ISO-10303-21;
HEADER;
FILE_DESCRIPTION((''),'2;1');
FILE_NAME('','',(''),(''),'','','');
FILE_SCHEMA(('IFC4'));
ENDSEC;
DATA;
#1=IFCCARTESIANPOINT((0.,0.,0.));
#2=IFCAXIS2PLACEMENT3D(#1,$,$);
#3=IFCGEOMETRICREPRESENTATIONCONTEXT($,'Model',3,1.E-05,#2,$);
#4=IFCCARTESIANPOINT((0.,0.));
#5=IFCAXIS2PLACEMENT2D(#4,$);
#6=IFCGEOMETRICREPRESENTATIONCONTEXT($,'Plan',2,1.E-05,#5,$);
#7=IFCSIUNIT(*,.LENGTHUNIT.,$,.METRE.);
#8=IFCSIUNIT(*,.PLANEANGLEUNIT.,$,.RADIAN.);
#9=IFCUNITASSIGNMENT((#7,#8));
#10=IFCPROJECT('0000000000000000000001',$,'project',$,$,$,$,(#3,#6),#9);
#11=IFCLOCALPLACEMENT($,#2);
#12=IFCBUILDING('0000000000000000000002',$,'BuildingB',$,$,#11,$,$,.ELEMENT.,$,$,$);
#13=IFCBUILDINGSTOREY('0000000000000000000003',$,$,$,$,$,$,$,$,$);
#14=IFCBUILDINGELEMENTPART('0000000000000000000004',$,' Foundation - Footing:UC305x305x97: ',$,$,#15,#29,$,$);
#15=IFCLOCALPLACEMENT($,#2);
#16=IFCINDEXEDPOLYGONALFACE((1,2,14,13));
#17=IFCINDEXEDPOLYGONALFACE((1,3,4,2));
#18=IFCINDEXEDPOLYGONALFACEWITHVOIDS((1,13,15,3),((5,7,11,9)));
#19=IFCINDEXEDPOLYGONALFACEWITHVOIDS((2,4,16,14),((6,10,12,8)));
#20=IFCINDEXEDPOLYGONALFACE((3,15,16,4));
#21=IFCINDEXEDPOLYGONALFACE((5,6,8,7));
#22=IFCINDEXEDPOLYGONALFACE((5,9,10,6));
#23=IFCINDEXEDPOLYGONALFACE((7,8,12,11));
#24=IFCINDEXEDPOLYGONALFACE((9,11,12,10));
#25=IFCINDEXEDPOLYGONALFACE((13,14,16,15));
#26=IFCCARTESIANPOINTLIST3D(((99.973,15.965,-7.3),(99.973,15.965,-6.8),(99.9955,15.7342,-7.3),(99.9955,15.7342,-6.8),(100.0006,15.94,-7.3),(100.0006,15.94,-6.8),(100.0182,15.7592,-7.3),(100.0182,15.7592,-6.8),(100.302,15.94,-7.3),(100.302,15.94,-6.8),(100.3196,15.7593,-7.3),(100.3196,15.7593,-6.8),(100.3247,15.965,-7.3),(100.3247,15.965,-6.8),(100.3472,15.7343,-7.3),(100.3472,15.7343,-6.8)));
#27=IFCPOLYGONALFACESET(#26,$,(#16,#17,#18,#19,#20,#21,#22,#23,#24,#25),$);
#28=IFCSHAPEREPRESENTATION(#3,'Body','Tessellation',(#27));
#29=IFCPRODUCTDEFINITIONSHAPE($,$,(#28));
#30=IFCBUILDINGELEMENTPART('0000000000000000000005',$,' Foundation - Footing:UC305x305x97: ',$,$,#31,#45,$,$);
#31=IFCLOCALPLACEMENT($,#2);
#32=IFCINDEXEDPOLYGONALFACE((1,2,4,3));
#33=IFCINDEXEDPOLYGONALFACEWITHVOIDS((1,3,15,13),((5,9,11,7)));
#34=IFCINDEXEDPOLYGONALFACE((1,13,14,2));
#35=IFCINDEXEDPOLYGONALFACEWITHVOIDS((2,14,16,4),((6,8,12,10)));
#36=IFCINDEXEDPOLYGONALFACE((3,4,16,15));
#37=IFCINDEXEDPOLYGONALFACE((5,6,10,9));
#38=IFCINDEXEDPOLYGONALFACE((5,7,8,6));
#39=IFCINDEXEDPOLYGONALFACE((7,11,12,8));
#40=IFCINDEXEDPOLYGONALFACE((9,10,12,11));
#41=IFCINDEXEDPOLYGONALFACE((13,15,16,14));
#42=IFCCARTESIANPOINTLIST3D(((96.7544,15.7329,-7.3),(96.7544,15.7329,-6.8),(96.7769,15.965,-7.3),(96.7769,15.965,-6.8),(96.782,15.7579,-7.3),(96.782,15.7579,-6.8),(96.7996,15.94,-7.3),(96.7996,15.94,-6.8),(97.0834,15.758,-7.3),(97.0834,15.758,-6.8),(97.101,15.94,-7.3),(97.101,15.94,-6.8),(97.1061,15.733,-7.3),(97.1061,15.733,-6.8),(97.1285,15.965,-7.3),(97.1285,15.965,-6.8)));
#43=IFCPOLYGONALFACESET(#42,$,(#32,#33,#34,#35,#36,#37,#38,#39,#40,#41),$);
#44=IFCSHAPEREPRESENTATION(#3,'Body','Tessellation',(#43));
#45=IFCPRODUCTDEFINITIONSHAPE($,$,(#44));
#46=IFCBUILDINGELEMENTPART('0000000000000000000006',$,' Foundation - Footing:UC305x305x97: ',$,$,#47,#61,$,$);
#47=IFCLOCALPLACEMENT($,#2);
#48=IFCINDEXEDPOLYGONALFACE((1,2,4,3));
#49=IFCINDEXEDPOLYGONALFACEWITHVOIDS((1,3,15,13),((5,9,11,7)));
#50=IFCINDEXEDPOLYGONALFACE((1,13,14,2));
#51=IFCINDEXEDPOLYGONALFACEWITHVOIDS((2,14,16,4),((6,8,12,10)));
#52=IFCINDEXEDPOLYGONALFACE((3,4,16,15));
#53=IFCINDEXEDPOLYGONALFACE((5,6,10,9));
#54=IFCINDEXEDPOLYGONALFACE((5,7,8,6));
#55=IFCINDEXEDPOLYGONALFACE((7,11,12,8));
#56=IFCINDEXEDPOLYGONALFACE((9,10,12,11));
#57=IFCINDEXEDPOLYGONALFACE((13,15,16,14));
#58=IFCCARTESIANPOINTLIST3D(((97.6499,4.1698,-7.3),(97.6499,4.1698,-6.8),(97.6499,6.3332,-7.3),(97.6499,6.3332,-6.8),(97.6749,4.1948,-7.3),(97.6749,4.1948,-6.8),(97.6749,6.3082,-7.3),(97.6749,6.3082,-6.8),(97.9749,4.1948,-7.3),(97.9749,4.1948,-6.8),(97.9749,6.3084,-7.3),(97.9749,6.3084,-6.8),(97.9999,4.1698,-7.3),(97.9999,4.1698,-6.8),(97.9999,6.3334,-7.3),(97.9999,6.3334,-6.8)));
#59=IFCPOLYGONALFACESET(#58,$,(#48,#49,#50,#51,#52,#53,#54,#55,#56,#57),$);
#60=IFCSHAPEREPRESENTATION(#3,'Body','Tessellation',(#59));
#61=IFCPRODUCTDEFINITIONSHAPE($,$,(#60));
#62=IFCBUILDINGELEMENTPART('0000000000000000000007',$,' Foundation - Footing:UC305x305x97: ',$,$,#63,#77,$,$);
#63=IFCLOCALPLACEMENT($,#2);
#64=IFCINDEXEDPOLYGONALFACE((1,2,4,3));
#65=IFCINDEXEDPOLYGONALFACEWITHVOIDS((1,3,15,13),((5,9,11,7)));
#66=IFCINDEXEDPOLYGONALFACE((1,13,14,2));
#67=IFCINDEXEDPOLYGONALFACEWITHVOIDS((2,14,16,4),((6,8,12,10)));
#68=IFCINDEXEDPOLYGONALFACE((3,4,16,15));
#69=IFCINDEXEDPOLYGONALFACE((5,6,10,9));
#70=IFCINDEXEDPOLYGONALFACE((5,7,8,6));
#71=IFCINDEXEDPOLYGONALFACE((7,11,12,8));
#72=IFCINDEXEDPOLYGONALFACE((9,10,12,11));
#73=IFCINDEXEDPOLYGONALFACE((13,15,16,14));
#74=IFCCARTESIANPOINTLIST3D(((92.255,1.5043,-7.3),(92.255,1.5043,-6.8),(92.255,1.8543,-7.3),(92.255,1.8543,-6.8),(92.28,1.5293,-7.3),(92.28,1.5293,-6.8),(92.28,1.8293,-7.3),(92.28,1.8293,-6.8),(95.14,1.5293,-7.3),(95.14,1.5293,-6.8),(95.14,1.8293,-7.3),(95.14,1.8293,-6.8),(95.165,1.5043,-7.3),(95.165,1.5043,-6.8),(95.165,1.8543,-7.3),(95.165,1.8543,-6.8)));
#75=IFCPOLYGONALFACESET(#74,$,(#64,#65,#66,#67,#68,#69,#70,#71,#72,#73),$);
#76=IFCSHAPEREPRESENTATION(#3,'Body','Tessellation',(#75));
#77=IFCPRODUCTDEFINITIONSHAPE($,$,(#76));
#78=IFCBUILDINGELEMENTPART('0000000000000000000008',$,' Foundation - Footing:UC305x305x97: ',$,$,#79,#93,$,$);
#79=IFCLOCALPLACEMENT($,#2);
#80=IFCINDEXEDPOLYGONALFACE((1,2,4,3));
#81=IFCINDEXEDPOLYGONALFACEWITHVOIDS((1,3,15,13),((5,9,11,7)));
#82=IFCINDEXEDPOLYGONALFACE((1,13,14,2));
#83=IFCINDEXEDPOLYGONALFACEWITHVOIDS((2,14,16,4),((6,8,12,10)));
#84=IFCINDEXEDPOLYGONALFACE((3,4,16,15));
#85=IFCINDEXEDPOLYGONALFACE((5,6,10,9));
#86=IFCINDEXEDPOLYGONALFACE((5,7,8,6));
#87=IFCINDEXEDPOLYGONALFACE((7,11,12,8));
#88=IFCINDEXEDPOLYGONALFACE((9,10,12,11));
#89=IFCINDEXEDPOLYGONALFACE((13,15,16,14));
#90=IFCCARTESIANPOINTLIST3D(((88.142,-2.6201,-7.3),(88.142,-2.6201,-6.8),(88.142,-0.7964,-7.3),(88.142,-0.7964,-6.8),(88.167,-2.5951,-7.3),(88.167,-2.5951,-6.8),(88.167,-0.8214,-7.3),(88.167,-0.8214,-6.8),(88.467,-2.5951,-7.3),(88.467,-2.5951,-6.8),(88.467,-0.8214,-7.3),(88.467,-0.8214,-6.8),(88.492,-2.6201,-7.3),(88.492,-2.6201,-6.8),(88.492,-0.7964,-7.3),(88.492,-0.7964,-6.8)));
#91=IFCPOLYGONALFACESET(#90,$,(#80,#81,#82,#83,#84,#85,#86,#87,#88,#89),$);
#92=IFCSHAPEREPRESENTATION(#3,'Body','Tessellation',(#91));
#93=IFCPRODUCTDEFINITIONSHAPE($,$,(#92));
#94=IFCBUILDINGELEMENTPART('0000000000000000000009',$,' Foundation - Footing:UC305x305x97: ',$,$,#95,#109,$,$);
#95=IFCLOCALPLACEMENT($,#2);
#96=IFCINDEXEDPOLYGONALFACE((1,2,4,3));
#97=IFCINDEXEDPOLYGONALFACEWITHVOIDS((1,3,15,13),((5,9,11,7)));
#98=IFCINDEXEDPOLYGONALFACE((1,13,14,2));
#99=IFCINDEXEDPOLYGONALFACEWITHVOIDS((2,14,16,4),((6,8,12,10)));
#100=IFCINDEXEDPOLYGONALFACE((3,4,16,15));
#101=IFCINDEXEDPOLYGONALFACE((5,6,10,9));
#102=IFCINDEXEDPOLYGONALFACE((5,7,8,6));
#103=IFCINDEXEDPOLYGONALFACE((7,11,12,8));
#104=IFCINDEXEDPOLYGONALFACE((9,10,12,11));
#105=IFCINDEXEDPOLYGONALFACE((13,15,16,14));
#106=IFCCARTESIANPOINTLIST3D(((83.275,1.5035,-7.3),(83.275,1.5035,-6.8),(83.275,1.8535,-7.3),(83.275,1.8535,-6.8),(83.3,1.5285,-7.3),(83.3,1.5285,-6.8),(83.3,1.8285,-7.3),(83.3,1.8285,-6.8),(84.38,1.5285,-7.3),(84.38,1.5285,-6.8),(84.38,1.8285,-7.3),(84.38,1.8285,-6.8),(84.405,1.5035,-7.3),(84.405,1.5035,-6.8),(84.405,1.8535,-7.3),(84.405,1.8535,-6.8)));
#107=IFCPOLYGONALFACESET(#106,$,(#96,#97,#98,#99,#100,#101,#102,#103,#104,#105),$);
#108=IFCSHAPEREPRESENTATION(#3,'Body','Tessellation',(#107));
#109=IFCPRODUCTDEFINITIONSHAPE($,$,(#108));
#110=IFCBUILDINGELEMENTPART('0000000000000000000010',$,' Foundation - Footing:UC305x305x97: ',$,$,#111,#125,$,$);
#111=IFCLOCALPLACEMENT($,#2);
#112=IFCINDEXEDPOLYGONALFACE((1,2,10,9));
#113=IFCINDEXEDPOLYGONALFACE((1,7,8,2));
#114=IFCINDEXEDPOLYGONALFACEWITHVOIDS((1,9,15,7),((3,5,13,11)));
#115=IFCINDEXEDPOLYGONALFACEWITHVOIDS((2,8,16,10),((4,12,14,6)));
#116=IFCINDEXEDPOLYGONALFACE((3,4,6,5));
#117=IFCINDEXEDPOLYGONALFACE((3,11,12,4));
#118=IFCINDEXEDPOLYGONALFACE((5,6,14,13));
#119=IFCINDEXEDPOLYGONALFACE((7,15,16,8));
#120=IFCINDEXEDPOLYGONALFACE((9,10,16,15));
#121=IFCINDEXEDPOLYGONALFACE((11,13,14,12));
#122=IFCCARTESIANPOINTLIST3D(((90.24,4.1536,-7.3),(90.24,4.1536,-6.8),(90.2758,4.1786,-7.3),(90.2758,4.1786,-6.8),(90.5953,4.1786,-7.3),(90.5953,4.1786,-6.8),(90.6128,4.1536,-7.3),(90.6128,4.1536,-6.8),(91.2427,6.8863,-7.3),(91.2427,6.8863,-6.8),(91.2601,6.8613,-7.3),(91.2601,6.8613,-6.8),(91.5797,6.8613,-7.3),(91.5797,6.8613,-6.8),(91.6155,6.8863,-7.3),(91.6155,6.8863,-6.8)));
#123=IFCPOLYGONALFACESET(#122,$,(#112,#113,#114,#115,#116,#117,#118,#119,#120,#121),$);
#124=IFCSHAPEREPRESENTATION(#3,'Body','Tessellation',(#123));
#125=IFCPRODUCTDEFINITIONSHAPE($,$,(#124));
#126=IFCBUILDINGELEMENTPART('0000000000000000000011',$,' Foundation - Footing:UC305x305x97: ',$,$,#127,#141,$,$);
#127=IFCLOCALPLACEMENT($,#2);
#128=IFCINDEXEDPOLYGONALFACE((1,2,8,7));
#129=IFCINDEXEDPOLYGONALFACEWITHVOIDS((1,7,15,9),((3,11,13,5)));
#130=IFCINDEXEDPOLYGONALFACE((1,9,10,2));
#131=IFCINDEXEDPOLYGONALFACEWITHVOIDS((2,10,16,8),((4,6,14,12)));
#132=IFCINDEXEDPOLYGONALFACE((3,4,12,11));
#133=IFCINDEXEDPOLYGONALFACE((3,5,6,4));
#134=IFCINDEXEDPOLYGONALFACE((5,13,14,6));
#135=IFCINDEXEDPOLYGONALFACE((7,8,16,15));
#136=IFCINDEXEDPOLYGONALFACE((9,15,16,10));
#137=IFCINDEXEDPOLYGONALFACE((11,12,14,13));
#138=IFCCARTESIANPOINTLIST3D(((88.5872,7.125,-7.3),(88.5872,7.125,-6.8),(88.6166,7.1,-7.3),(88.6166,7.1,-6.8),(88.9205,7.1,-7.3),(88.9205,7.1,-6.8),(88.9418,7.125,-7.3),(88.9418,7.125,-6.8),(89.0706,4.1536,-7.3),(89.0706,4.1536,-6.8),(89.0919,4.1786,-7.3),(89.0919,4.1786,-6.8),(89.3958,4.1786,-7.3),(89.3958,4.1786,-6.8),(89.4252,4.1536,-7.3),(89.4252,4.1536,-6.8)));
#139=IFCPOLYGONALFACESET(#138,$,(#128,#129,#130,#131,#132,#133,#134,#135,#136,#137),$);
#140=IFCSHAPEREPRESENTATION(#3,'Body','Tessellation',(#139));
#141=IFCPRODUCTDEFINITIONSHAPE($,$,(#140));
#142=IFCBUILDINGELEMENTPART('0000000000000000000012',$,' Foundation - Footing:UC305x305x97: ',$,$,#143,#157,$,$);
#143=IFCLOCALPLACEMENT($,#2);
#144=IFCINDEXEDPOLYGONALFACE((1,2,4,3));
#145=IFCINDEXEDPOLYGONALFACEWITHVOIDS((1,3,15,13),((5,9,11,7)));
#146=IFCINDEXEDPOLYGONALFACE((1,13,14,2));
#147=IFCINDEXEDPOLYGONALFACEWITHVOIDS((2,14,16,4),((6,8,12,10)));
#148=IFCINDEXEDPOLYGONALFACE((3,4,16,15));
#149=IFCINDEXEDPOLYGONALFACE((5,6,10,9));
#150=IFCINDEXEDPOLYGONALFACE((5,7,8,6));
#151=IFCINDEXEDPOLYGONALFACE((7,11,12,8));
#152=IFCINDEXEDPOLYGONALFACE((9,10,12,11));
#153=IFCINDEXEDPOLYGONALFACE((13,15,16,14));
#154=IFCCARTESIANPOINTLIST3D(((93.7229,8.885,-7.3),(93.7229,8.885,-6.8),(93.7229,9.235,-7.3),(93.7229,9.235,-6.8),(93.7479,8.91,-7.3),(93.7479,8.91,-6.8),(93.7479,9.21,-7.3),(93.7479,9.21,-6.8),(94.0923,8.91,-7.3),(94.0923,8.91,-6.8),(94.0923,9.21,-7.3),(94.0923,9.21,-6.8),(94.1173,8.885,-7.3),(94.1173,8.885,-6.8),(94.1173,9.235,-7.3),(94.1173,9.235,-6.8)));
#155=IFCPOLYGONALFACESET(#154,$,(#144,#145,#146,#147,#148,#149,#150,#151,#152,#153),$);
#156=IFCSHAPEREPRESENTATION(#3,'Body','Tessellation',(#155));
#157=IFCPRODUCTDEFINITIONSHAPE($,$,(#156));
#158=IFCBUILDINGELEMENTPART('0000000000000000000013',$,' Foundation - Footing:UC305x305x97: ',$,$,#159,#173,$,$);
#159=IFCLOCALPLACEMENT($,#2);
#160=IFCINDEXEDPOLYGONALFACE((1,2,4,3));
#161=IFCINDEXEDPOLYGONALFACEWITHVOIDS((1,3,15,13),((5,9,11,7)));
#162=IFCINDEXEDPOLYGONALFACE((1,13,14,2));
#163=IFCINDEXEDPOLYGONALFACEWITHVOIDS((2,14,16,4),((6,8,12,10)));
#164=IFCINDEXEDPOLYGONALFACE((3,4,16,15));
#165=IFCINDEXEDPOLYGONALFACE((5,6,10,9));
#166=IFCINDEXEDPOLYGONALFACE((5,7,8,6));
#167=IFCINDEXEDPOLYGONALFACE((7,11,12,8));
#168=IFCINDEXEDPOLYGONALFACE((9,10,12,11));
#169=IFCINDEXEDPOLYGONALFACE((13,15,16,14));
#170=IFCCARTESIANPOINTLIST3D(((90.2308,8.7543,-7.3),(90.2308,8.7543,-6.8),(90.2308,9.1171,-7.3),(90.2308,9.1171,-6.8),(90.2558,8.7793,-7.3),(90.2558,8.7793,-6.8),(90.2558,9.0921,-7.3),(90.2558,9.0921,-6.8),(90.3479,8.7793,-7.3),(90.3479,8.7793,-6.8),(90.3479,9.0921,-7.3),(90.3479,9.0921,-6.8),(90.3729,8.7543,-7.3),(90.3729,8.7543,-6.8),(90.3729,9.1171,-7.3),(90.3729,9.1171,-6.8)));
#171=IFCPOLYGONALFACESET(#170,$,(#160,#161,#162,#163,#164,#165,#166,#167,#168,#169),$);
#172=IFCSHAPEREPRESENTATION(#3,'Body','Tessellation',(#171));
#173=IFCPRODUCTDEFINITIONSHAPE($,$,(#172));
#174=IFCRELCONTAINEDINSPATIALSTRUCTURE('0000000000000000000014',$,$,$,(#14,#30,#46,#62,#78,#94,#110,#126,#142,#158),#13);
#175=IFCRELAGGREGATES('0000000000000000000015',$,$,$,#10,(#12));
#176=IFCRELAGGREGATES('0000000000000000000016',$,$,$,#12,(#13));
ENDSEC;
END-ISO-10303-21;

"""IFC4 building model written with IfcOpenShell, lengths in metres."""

from ifc_helpers import new_model, si_unit, origin, origin_2d, place, context, project, spatial, polyline, outline, extrude, element, save


model = new_model("IFC4")

# Units and contexts
model_context = context("Model", 3, precision=1e-05, world=origin())
plan_context = context("Plan", 2, precision=1e-05, world=origin_2d())
ifc_project = project(units=[si_unit("LENGTHUNIT", "METRE"), si_unit("PLANEANGLEUNIT", "RADIAN")], contexts=[model_context, plan_context])

# Building, storey
building_placement = place(None, origin())
building = spatial("IfcBuilding", under=ifc_project, at=building_placement, Name="BuildingB", CompositionType="ELEMENT")
storey = spatial("IfcBuildingStorey", under=building)

# Building element parts, openings
building_element_part_1 = element("IfcBuildingElementPart", 1, inside=storey, Name=" Foundation - Footing:UC305x305x97: ", context=model_context, shape_type="SweptSolid", body=[
    extrude(outline(polyline([(100.3472, 15.7343, -7.3), (100.3247, 15.965, -7.3), (99.973, 15.965, -7.3), (99.9955, 15.7342, -7.3), (100.3472, 15.7343, -7.3)])), None, (0.0, 0.0, 1.0), 0.5),
])
element("IfcOpeningElement", 2, inside=storey, cuts=building_element_part_1, context=model_context, shape_type="SweptSolid", body=[
    extrude(outline(polyline([(100.3196, 15.7593, -7.3), (100.302, 15.94, -7.3), (100.0006, 15.94, -7.3), (100.0182, 15.7592, -7.3), (100.3196, 15.7593, -7.3)])), None, (0.0, 0.0, 1.0), 0.5),
])
building_element_part_2 = element("IfcBuildingElementPart", 3, inside=storey, Name=" Foundation - Footing:UC305x305x97: ", context=model_context, shape_type="SweptSolid", body=[
    extrude(outline(polyline([(97.1061, 15.733, -7.3), (97.1285, 15.965, -7.3), (96.7769, 15.965, -7.3), (96.7544, 15.7329, -7.3), (97.1061, 15.733, -7.3)])), None, (0.0, 0.0, 1.0), 0.5),
])
element("IfcOpeningElement", 4, inside=storey, cuts=building_element_part_2, context=model_context, shape_type="SweptSolid", body=[
    extrude(outline(polyline([(97.0834, 15.758, -7.3), (97.101, 15.94, -7.3), (96.7996, 15.94, -7.3), (96.782, 15.7579, -7.3), (97.0834, 15.758, -7.3)])), None, (0.0, 0.0, 1.0), 0.5),
])
building_element_part_3 = element("IfcBuildingElementPart", 5, inside=storey, Name=" Foundation - Footing:UC305x305x97: ", context=model_context, shape_type="SweptSolid", body=[
    extrude(outline(polyline([(97.9999, 4.1698, -7.3), (97.9999, 6.3334, -7.3), (97.6499, 6.3332, -7.3), (97.6499, 4.1698, -7.3), (97.9999, 4.1698, -7.3)])), None, (0.0, 0.0, 1.0), 0.5),
])
element("IfcOpeningElement", 6, inside=storey, cuts=building_element_part_3, context=model_context, shape_type="SweptSolid", body=[
    extrude(outline(polyline([(97.9749, 4.1948, -7.3), (97.9749, 6.3084, -7.3), (97.6749, 6.3082, -7.3), (97.6749, 4.1948, -7.3), (97.9749, 4.1948, -7.3)])), None, (0.0, 0.0, 1.0), 0.5),
])
building_element_part_4 = element("IfcBuildingElementPart", 7, inside=storey, Name=" Foundation - Footing:UC305x305x97: ", context=model_context, shape_type="SweptSolid", body=[
    extrude(outline(polyline([(95.165, 1.5043, -7.3), (95.165, 1.8543, -7.3), (92.255, 1.8543, -7.3), (92.255, 1.5043, -7.3), (95.165, 1.5043, -7.3)])), None, (0.0, 0.0, 1.0), 0.5),
])
element("IfcOpeningElement", 8, inside=storey, cuts=building_element_part_4, context=model_context, shape_type="SweptSolid", body=[
    extrude(outline(polyline([(95.14, 1.5293, -7.3), (95.14, 1.8293, -7.3), (92.28, 1.8293, -7.3), (92.28, 1.5293, -7.3), (95.14, 1.5293, -7.3)])), None, (0.0, 0.0, 1.0), 0.5),
])
building_element_part_5 = element("IfcBuildingElementPart", 9, inside=storey, Name=" Foundation - Footing:UC305x305x97: ", context=model_context, shape_type="SweptSolid", body=[
    extrude(outline(polyline([(88.492, -2.6201, -7.3), (88.492, -0.7964, -7.3), (88.142, -0.7964, -7.3), (88.142, -2.6201, -7.3), (88.492, -2.6201, -7.3)])), None, (0.0, 0.0, 1.0), 0.5),
])
element("IfcOpeningElement", 10, inside=storey, cuts=building_element_part_5, context=model_context, shape_type="SweptSolid", body=[
    extrude(outline(polyline([(88.467, -2.5951, -7.3), (88.467, -0.8214, -7.3), (88.167, -0.8214, -7.3), (88.167, -2.5951, -7.3), (88.467, -2.5951, -7.3)])), None, (0.0, 0.0, 1.0), 0.5),
])
building_element_part_6 = element("IfcBuildingElementPart", 11, inside=storey, Name=" Foundation - Footing:UC305x305x97: ", context=model_context, shape_type="SweptSolid", body=[
    extrude(outline(polyline([(84.405, 1.5035, -7.3), (84.405, 1.8535, -7.3), (83.275, 1.8535, -7.3), (83.275, 1.5035, -7.3), (84.405, 1.5035, -7.3)])), None, (0.0, 0.0, 1.0), 0.5),
])
element("IfcOpeningElement", 12, inside=storey, cuts=building_element_part_6, context=model_context, shape_type="SweptSolid", body=[
    extrude(outline(polyline([(84.38, 1.5285, -7.3), (84.38, 1.8285, -7.3), (83.3, 1.8285, -7.3), (83.3, 1.5285, -7.3), (84.38, 1.5285, -7.3)])), None, (0.0, 0.0, 1.0), 0.5),
])
building_element_part_7 = element("IfcBuildingElementPart", 13, inside=storey, Name=" Foundation - Footing:UC305x305x97: ", context=model_context, shape_type="SweptSolid", body=[
    extrude(outline(polyline([(90.6128, 4.1536, -7.3), (90.24, 4.1536, -7.3), (91.2427, 6.8863, -7.3), (91.6155, 6.8863, -7.3), (90.6128, 4.1536, -7.3)])), None, (0.0, 0.0, 1.0), 0.5),
])
element("IfcOpeningElement", 14, inside=storey, cuts=building_element_part_7, context=model_context, shape_type="SweptSolid", body=[
    extrude(outline(polyline([(90.5953, 4.1786, -7.3), (90.2758, 4.1786, -7.3), (91.2601, 6.8613, -7.3), (91.5797, 6.8613, -7.3), (90.5953, 4.1786, -7.3)])), None, (0.0, 0.0, 1.0), 0.5),
])
building_element_part_8 = element("IfcBuildingElementPart", 15, inside=storey, Name=" Foundation - Footing:UC305x305x97: ", context=model_context, shape_type="SweptSolid", body=[
    extrude(outline(polyline([(89.4252, 4.1536, -7.3), (89.0706, 4.1536, -7.3), (88.5872, 7.125, -7.3), (88.9418, 7.125, -7.3), (89.4252, 4.1536, -7.3)])), None, (0.0, 0.0, 1.0), 0.5),
])
element("IfcOpeningElement", 16, inside=storey, cuts=building_element_part_8, context=model_context, shape_type="SweptSolid", body=[
    extrude(outline(polyline([(89.3958, 4.1786, -7.3), (89.0919, 4.1786, -7.3), (88.6166, 7.1, -7.3), (88.9205, 7.1, -7.3), (89.3958, 4.1786, -7.3)])), None, (0.0, 0.0, 1.0), 0.5),
])
building_element_part_9 = element("IfcBuildingElementPart", 17, inside=storey, Name=" Foundation - Footing:UC305x305x97: ", context=model_context, shape_type="SweptSolid", body=[
    extrude(outline(polyline([(94.1173, 8.885, -7.3), (94.1173, 9.235, -7.3), (93.7229, 9.235, -7.3), (93.7229, 8.885, -7.3), (94.1173, 8.885, -7.3)])), None, (0.0, 0.0, 1.0), 0.5),
])
element("IfcOpeningElement", 18, inside=storey, cuts=building_element_part_9, context=model_context, shape_type="SweptSolid", body=[
    extrude(outline(polyline([(94.0923, 8.91, -7.3), (94.0923, 9.21, -7.3), (93.7479, 9.21, -7.3), (93.7479, 8.91, -7.3), (94.0923, 8.91, -7.3)])), None, (0.0, 0.0, 1.0), 0.5),
])
building_element_part_10 = element("IfcBuildingElementPart", 19, inside=storey, Name=" Foundation - Footing:UC305x305x97: ", context=model_context, shape_type="SweptSolid", body=[
    extrude(outline(polyline([(90.3729, 8.7543, -7.3), (90.2308, 8.7543, -7.3), (90.2308, 9.1171, -7.3), (90.3729, 9.1171, -7.3), (90.3729, 8.7543, -7.3)])), None, (0.0, 0.0, 1.0), 0.5),
])
element("IfcOpeningElement", 20, inside=storey, cuts=building_element_part_10, context=model_context, shape_type="SweptSolid", body=[
    extrude(outline(polyline([(90.3479, 8.7793, -7.3), (90.2558, 8.7793, -7.3), (90.2558, 9.0921, -7.3), (90.3479, 9.0921, -7.3), (90.3479, 8.7793, -7.3)])), None, (0.0, 0.0, 1.0), 0.5),
])

save(model, "model.ifc")
